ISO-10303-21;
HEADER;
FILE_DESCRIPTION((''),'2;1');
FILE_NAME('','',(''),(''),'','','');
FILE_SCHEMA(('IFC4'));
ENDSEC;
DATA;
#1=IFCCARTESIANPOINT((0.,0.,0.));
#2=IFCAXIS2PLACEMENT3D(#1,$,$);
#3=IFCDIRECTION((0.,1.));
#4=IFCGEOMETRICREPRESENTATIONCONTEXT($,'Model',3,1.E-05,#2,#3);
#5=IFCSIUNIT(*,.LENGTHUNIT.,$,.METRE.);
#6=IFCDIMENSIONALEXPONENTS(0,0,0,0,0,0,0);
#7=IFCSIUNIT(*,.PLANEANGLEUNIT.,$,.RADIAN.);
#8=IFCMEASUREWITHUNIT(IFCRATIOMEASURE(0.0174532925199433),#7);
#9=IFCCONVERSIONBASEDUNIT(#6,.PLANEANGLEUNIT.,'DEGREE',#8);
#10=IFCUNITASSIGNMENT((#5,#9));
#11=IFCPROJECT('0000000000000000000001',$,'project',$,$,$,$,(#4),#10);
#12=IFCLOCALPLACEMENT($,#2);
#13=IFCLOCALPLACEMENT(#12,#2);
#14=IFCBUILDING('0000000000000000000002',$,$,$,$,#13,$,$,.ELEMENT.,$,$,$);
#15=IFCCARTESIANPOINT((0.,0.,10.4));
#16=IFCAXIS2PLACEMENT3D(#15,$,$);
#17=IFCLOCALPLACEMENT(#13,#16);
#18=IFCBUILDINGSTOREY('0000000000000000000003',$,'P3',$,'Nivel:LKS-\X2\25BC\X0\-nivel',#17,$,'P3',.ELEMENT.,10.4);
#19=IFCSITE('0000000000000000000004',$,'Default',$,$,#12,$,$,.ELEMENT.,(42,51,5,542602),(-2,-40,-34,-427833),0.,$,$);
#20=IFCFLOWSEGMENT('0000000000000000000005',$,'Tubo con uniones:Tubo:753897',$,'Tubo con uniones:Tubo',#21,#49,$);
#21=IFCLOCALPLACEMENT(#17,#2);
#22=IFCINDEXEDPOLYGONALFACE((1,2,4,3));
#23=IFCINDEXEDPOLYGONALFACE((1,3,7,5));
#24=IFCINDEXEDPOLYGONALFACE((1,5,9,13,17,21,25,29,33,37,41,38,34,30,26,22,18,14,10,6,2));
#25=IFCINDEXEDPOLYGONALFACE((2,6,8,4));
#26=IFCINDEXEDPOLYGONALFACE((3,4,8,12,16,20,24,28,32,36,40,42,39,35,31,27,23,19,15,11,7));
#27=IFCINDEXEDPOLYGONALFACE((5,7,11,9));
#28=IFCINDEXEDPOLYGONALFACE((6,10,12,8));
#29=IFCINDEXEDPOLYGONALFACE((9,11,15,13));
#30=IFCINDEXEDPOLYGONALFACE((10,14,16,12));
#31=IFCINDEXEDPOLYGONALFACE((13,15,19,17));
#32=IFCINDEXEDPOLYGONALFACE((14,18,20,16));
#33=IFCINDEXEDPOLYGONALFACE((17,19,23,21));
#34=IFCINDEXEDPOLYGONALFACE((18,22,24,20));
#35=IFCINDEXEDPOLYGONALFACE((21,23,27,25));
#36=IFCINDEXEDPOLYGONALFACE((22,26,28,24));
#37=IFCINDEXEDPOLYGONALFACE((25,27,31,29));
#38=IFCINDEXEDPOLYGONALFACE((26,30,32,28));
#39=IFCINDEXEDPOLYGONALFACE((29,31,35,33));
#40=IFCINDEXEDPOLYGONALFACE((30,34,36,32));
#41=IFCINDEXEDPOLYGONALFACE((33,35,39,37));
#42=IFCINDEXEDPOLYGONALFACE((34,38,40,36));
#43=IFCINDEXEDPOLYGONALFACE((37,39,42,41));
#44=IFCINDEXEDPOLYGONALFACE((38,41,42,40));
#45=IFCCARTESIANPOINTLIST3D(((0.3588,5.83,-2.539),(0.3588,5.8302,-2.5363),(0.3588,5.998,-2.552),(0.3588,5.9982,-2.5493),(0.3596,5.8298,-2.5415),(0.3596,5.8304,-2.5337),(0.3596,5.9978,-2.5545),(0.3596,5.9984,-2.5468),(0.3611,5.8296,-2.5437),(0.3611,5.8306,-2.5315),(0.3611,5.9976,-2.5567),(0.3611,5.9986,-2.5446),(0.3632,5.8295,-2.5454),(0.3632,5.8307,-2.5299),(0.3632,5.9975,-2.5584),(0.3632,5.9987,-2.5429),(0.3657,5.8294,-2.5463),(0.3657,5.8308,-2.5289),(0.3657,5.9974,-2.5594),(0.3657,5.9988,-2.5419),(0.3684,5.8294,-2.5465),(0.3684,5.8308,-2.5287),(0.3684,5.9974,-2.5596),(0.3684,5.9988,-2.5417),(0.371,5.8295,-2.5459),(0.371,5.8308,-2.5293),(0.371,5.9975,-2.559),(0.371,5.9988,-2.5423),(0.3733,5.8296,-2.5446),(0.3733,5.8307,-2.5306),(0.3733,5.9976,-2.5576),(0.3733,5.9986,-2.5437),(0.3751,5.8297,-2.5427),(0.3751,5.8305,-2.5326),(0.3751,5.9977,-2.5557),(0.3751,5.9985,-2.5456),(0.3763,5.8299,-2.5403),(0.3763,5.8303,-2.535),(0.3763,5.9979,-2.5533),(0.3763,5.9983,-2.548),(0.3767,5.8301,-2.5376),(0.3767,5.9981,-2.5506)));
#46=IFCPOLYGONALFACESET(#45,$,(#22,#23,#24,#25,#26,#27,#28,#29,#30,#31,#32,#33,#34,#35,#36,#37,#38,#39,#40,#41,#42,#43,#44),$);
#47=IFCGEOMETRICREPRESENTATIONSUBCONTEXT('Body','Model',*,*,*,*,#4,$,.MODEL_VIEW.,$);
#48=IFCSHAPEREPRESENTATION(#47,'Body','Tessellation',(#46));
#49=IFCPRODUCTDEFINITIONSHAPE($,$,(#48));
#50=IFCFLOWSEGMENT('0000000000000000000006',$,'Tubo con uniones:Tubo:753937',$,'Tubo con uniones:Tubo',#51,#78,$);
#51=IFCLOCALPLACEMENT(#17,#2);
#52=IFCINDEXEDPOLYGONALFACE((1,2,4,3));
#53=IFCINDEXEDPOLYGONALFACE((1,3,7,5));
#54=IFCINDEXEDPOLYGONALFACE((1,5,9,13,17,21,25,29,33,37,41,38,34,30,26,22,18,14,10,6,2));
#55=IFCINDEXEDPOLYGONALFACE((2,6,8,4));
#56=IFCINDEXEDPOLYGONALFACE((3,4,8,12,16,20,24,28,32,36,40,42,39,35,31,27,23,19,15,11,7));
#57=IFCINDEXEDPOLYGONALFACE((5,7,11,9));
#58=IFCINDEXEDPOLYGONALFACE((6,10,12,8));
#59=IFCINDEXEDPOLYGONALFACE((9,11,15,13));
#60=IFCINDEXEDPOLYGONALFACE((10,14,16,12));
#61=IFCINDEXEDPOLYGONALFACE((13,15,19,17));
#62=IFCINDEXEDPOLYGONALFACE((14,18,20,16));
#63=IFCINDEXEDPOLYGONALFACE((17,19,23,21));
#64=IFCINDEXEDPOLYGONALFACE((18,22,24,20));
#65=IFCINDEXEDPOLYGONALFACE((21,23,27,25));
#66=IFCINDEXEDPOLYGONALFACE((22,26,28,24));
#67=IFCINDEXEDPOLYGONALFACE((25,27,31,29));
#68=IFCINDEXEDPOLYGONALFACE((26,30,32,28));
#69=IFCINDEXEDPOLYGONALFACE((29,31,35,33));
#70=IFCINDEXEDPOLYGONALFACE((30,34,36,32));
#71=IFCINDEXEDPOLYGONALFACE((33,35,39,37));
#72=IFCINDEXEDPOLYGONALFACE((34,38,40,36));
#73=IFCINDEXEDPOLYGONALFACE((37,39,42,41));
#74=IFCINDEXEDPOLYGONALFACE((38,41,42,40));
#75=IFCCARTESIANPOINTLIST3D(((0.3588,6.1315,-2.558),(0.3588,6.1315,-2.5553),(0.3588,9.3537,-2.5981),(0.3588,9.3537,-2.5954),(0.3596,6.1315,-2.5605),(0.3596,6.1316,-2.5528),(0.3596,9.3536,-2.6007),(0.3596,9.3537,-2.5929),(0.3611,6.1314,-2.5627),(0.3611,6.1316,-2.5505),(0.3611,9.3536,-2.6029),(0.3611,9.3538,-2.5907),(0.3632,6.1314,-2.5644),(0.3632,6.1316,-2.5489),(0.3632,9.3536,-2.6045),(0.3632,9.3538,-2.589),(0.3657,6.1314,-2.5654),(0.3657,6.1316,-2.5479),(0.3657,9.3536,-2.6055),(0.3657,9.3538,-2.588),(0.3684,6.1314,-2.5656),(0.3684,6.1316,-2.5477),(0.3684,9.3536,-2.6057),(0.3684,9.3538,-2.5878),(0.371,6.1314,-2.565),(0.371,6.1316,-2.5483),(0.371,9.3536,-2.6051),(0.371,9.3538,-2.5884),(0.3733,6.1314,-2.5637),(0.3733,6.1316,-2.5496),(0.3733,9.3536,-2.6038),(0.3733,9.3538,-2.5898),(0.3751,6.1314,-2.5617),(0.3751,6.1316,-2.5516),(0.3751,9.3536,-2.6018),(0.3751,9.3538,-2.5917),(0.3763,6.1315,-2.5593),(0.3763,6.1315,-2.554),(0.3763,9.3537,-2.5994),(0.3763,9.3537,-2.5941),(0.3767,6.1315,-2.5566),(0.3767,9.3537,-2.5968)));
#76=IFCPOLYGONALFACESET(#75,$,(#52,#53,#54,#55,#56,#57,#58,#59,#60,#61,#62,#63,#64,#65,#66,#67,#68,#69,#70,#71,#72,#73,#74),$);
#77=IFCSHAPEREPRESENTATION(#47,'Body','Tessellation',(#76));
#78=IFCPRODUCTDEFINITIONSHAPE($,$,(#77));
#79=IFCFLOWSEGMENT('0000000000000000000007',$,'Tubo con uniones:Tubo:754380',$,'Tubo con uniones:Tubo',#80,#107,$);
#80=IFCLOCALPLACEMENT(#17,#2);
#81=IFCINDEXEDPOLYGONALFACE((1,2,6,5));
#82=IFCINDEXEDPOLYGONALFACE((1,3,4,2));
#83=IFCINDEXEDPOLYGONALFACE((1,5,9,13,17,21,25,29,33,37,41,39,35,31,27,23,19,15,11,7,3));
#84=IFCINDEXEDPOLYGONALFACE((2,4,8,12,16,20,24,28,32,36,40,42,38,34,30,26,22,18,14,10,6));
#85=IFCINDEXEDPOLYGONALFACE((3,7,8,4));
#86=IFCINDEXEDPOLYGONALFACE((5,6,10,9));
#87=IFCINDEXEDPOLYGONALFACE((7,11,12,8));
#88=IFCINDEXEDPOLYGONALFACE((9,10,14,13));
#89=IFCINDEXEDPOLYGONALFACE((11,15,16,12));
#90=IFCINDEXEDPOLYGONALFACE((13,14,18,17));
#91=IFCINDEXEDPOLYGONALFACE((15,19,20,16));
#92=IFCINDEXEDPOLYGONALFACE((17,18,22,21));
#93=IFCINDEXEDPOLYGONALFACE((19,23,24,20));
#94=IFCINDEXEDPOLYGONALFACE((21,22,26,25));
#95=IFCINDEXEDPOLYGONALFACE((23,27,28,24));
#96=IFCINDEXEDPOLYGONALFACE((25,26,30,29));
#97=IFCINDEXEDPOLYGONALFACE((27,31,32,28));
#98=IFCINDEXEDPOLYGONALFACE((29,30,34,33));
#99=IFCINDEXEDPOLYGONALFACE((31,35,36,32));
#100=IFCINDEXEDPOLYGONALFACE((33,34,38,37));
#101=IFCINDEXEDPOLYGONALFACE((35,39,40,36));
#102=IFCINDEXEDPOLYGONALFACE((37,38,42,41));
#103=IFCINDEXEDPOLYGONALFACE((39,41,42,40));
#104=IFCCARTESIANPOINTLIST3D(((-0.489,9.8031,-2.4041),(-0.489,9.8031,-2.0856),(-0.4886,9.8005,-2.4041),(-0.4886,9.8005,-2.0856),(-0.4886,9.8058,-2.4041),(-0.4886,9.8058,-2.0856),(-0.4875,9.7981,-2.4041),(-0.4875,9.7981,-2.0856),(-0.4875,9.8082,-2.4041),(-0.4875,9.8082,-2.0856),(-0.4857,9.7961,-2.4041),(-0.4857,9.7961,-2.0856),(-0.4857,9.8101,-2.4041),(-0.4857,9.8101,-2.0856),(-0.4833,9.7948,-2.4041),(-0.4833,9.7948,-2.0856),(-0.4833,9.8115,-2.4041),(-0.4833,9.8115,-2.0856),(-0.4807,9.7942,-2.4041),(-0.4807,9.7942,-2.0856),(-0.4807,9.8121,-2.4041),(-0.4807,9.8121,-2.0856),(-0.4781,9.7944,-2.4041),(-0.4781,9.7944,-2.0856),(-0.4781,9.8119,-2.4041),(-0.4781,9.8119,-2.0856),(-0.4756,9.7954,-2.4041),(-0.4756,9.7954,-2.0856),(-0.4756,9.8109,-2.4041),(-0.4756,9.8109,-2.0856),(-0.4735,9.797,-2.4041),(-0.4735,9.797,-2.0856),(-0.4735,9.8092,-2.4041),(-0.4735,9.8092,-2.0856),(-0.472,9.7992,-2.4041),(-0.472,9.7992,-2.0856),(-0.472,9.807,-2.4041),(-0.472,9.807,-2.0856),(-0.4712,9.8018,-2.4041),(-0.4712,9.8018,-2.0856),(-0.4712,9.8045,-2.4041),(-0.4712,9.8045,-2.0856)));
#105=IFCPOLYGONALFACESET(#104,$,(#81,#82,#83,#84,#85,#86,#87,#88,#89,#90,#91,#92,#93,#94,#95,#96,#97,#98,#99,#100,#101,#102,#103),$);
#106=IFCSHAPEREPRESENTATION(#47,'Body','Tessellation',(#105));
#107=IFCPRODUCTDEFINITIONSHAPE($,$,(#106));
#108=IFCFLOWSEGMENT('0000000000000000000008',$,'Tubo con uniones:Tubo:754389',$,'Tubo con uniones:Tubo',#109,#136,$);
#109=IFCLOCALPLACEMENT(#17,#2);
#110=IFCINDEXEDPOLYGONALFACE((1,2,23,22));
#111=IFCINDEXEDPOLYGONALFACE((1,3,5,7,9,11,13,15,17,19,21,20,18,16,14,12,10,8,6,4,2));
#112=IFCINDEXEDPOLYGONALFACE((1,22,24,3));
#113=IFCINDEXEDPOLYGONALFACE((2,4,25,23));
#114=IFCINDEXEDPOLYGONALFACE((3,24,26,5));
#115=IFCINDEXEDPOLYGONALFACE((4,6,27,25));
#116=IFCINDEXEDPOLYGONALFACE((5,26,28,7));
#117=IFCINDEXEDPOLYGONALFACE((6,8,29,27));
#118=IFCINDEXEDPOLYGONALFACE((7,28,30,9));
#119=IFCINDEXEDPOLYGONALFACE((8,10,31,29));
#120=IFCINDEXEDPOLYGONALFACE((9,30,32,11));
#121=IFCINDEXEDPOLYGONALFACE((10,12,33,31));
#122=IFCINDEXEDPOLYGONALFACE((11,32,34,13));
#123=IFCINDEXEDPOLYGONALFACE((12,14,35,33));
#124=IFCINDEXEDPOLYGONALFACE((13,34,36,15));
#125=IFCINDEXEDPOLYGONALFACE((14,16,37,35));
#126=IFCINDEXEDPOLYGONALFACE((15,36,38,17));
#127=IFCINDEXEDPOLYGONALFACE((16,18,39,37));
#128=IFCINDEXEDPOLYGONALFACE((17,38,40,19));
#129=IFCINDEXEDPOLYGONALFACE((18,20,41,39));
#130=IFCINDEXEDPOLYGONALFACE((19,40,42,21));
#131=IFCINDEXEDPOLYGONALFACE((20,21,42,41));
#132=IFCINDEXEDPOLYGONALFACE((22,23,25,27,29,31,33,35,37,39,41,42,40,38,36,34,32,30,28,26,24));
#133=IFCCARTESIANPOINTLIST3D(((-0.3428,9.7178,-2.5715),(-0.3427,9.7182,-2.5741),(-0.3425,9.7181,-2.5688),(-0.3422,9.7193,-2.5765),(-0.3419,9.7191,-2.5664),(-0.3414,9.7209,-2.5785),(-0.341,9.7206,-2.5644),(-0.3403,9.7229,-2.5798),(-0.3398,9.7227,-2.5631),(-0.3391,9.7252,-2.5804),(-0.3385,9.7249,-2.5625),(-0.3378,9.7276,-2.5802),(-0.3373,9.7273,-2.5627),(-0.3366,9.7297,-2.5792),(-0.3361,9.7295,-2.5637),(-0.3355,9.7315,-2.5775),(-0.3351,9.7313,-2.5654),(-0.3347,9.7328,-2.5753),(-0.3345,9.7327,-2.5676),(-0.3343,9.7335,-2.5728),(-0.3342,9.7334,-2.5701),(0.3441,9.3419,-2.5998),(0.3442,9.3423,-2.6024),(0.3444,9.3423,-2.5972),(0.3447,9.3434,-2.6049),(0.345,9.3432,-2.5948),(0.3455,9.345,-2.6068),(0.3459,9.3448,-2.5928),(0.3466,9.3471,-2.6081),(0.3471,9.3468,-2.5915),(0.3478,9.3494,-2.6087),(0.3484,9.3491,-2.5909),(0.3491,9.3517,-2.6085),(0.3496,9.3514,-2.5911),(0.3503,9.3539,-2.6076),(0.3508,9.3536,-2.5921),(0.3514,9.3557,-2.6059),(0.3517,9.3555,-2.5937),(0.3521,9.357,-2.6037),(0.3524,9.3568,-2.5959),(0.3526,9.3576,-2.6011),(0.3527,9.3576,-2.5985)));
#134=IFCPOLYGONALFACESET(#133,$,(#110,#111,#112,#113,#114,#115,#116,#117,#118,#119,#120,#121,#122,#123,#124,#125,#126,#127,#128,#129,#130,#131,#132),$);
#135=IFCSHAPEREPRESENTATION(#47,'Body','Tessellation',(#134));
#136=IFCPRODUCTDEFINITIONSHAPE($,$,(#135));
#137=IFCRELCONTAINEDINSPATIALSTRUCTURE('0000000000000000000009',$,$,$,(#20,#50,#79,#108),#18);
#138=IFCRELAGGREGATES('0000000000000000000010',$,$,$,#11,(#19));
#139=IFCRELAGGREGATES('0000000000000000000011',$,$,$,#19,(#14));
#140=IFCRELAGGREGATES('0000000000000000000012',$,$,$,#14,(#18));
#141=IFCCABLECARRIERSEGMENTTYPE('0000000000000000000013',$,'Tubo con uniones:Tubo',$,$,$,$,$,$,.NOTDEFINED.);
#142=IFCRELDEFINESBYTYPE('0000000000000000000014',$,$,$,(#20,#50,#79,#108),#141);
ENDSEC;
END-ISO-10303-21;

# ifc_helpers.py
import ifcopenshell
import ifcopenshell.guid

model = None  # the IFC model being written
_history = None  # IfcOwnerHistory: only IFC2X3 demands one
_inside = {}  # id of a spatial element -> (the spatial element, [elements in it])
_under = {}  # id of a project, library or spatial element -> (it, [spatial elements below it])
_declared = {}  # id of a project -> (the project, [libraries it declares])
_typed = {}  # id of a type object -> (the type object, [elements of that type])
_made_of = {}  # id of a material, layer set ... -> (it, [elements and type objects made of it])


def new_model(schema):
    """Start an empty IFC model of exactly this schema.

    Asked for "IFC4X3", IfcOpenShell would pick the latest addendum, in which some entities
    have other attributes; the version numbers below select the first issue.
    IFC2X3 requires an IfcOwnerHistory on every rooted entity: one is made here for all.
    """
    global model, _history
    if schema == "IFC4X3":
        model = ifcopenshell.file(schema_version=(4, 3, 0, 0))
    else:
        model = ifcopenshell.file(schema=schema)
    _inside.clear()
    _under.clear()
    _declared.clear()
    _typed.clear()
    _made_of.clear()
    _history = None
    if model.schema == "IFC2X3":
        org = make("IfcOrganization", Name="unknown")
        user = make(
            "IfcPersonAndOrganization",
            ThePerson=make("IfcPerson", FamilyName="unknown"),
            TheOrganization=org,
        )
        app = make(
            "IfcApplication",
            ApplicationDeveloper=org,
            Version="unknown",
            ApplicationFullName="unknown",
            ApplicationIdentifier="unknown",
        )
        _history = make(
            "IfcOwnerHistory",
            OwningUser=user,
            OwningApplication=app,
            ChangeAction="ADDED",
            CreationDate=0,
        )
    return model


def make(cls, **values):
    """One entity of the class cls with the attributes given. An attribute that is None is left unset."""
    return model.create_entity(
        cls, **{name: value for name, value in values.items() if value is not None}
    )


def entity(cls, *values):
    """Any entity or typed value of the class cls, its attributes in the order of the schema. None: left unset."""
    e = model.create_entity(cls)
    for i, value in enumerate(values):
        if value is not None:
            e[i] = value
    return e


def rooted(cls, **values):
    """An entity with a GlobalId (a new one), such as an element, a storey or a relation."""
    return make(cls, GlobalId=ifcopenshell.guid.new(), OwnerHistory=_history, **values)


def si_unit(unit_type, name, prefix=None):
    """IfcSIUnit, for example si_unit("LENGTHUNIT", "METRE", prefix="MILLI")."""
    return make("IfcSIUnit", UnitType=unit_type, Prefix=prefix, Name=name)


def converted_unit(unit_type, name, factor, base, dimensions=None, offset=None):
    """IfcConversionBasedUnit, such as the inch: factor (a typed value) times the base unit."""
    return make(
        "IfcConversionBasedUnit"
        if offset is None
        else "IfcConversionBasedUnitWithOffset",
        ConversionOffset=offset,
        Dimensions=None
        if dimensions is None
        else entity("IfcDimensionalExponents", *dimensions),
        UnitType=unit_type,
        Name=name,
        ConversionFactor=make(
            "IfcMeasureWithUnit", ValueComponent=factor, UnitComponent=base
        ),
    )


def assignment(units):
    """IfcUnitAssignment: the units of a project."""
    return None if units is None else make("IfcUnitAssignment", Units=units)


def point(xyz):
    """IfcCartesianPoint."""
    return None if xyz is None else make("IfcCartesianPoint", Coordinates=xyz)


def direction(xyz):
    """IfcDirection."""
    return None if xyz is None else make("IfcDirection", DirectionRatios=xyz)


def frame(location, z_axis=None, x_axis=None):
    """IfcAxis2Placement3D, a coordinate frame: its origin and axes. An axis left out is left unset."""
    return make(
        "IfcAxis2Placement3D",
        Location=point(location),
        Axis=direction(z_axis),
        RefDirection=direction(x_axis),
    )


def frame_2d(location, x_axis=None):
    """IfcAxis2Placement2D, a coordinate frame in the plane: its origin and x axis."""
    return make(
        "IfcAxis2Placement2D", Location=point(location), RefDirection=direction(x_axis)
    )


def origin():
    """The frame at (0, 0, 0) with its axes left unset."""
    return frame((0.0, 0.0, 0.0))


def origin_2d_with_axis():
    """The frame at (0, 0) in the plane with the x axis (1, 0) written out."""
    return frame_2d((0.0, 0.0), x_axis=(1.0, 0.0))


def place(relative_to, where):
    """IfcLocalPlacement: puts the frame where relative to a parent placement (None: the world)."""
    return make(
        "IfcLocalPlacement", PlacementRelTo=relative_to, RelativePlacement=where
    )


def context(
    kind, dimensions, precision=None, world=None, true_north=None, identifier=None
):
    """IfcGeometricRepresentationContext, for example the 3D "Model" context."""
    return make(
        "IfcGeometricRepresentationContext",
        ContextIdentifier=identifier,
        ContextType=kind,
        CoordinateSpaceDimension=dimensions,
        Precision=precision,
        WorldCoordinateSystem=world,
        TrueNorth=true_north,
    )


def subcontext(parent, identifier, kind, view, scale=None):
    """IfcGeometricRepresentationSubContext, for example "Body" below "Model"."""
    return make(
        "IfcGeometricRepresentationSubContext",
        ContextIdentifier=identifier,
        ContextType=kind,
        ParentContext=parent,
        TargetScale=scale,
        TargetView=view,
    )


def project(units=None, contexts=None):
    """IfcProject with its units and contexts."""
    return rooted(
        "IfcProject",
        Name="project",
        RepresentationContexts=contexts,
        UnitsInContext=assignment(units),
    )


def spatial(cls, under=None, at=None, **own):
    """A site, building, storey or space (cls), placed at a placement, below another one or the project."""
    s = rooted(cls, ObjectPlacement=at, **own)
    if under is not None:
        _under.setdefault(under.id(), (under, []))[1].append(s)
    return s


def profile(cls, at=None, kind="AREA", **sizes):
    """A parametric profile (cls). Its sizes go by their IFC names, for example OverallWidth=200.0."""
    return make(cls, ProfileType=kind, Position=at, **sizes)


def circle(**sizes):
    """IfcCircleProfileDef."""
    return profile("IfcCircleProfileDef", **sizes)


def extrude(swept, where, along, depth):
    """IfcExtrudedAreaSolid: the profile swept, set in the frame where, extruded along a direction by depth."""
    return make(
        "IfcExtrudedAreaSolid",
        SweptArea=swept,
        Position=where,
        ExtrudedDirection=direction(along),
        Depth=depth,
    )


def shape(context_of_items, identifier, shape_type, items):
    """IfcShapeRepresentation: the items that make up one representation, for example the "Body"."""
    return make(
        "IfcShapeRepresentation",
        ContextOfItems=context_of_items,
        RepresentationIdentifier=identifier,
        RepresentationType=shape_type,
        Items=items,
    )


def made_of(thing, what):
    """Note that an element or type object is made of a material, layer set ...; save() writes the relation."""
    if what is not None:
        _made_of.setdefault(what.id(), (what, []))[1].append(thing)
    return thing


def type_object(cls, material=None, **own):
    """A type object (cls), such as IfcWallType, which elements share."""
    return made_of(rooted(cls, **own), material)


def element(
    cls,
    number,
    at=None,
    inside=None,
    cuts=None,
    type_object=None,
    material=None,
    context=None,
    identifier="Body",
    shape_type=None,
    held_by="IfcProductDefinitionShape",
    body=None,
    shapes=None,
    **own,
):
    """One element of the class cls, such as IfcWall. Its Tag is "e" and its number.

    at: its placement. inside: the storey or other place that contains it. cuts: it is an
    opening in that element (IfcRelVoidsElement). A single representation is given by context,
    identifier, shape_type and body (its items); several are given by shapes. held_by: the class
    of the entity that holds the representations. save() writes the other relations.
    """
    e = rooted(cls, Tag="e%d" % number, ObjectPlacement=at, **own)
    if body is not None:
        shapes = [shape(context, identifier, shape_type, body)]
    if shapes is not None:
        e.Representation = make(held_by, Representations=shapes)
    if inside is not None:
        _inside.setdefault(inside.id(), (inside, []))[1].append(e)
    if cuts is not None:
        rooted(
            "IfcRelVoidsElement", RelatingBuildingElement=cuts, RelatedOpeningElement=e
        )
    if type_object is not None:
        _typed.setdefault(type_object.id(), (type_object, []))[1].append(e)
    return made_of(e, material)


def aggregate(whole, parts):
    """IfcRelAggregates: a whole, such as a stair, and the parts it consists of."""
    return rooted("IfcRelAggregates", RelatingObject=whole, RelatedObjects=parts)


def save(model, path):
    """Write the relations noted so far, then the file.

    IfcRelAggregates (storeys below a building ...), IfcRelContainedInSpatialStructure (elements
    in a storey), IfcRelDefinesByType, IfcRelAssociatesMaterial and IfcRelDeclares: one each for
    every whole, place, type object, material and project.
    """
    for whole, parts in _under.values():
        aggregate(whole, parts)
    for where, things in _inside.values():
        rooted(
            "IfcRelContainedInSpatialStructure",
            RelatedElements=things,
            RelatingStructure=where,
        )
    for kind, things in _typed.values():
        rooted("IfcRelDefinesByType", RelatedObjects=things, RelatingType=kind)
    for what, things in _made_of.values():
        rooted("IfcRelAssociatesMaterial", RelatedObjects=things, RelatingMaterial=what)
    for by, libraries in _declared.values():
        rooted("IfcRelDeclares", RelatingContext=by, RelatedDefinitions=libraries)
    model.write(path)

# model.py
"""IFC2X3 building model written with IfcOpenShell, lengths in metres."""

from ifc_helpers import new_model, entity, si_unit, converted_unit, direction, frame, frame_2d, origin, origin_2d_with_axis, place, context, subcontext, project, spatial, circle, extrude, type_object, element, save


model = new_model("IFC2X3")

# Units and contexts
model_context = context("Model", 3, precision=1e-05, world=origin(), true_north=direction((0.0, 1.0)))
body_context = subcontext(model_context, "Body", "Model", "MODEL_VIEW")
ifc_project = project(units=[si_unit("LENGTHUNIT", "METRE"), converted_unit("PLANEANGLEUNIT", "DEGREE", entity("IfcRatioMeasure", 0.0174532925199433), si_unit("PLANEANGLEUNIT", "RADIAN"), dimensions=[0, 0, 0, 0, 0, 0, 0])], contexts=[model_context])

# Site, building, storey
site_placement = place(None, origin())
site = spatial("IfcSite", under=ifc_project, at=site_placement, Name="Default", CompositionType="ELEMENT", RefLatitude=(42, 51, 5, 542602), RefLongitude=(-2, -40, -34, -427833), RefElevation=0.0)
building_placement = place(site_placement, origin())
building = spatial("IfcBuilding", under=site, at=building_placement, CompositionType="ELEMENT")
storey_placement = place(building_placement, frame((0.0, 0.0, 10.4)))
storey = spatial("IfcBuildingStorey", under=building, at=storey_placement, Name="P3", ObjectType="Nivel:LKS-▼-nivel", LongName="P3", CompositionType="ELEMENT", Elevation=10.4)

# Flow segments
cable_carrier_segment_type = type_object("IfcCableCarrierSegmentType", Name="Tubo con uniones:Tubo", PredefinedType="NOTDEFINED")
flow_segment_1_placement = place(storey_placement, origin())
element("IfcFlowSegment", 1, at=flow_segment_1_placement, inside=storey, type_object=cable_carrier_segment_type, Name="Tubo con uniones:Tubo:753897", ObjectType="Tubo con uniones:Tubo", context=body_context, shape_type="SweptSolid", body=[
    extrude(circle(Radius=0.009, at=frame_2d((0.0, 0.0), x_axis=(1.0, 0.0))), frame((0.3677, 5.8301, -2.5376), z_axis=(0.0, 0.997007, -0.077317), x_axis=(1.0, 0.0, 0.0)), (0.0, 0.0, 1.0), 0.1685),
])
flow_segment_2_placement = place(storey_placement, origin())
element("IfcFlowSegment", 2, at=flow_segment_2_placement, inside=storey, type_object=cable_carrier_segment_type, Name="Tubo con uniones:Tubo:753937", ObjectType="Tubo con uniones:Tubo", context=body_context, shape_type="SweptSolid", body=[
    extrude(circle(Radius=0.009, at=frame_2d((0.0, 0.0), x_axis=(1.0, 0.0))), frame((0.3677, 9.3537, -2.5968), z_axis=(0.0, -0.999922, 0.012457), x_axis=(1.0, 0.0, 0.0)), (0.0, 0.0, 1.0), 3.2224),
])
flow_segment_3_placement = place(storey_placement, origin())
element("IfcFlowSegment", 3, at=flow_segment_3_placement, inside=storey, type_object=cable_carrier_segment_type, Name="Tubo con uniones:Tubo:754380", ObjectType="Tubo con uniones:Tubo", context=body_context, shape_type="SweptSolid", body=[
    extrude(circle(Radius=0.009, at=origin_2d_with_axis()), frame((-0.4801, 9.8031, -2.4041), z_axis=(0.0, 0.0, 1.0), x_axis=(-1.0, 0.0, 0.0)), (0.0, 0.0, 1.0), 0.3185),
])
flow_segment_4_placement = place(storey_placement, origin())
element("IfcFlowSegment", 4, at=flow_segment_4_placement, inside=storey, type_object=cable_carrier_segment_type, Name="Tubo con uniones:Tubo:754389", ObjectType="Tubo con uniones:Tubo", context=body_context, shape_type="SweptSolid", body=[
    extrude(circle(Radius=0.009, at=origin_2d_with_axis()), frame((0.3484, 9.3498, -2.5998), z_axis=(-0.876682, 0.479708, 0.036191), x_axis=(-0.480022, -0.877256, 0.0)), (0.0, 0.0, 1.0), 0.7835),
])

save(model, "model.ifc")
